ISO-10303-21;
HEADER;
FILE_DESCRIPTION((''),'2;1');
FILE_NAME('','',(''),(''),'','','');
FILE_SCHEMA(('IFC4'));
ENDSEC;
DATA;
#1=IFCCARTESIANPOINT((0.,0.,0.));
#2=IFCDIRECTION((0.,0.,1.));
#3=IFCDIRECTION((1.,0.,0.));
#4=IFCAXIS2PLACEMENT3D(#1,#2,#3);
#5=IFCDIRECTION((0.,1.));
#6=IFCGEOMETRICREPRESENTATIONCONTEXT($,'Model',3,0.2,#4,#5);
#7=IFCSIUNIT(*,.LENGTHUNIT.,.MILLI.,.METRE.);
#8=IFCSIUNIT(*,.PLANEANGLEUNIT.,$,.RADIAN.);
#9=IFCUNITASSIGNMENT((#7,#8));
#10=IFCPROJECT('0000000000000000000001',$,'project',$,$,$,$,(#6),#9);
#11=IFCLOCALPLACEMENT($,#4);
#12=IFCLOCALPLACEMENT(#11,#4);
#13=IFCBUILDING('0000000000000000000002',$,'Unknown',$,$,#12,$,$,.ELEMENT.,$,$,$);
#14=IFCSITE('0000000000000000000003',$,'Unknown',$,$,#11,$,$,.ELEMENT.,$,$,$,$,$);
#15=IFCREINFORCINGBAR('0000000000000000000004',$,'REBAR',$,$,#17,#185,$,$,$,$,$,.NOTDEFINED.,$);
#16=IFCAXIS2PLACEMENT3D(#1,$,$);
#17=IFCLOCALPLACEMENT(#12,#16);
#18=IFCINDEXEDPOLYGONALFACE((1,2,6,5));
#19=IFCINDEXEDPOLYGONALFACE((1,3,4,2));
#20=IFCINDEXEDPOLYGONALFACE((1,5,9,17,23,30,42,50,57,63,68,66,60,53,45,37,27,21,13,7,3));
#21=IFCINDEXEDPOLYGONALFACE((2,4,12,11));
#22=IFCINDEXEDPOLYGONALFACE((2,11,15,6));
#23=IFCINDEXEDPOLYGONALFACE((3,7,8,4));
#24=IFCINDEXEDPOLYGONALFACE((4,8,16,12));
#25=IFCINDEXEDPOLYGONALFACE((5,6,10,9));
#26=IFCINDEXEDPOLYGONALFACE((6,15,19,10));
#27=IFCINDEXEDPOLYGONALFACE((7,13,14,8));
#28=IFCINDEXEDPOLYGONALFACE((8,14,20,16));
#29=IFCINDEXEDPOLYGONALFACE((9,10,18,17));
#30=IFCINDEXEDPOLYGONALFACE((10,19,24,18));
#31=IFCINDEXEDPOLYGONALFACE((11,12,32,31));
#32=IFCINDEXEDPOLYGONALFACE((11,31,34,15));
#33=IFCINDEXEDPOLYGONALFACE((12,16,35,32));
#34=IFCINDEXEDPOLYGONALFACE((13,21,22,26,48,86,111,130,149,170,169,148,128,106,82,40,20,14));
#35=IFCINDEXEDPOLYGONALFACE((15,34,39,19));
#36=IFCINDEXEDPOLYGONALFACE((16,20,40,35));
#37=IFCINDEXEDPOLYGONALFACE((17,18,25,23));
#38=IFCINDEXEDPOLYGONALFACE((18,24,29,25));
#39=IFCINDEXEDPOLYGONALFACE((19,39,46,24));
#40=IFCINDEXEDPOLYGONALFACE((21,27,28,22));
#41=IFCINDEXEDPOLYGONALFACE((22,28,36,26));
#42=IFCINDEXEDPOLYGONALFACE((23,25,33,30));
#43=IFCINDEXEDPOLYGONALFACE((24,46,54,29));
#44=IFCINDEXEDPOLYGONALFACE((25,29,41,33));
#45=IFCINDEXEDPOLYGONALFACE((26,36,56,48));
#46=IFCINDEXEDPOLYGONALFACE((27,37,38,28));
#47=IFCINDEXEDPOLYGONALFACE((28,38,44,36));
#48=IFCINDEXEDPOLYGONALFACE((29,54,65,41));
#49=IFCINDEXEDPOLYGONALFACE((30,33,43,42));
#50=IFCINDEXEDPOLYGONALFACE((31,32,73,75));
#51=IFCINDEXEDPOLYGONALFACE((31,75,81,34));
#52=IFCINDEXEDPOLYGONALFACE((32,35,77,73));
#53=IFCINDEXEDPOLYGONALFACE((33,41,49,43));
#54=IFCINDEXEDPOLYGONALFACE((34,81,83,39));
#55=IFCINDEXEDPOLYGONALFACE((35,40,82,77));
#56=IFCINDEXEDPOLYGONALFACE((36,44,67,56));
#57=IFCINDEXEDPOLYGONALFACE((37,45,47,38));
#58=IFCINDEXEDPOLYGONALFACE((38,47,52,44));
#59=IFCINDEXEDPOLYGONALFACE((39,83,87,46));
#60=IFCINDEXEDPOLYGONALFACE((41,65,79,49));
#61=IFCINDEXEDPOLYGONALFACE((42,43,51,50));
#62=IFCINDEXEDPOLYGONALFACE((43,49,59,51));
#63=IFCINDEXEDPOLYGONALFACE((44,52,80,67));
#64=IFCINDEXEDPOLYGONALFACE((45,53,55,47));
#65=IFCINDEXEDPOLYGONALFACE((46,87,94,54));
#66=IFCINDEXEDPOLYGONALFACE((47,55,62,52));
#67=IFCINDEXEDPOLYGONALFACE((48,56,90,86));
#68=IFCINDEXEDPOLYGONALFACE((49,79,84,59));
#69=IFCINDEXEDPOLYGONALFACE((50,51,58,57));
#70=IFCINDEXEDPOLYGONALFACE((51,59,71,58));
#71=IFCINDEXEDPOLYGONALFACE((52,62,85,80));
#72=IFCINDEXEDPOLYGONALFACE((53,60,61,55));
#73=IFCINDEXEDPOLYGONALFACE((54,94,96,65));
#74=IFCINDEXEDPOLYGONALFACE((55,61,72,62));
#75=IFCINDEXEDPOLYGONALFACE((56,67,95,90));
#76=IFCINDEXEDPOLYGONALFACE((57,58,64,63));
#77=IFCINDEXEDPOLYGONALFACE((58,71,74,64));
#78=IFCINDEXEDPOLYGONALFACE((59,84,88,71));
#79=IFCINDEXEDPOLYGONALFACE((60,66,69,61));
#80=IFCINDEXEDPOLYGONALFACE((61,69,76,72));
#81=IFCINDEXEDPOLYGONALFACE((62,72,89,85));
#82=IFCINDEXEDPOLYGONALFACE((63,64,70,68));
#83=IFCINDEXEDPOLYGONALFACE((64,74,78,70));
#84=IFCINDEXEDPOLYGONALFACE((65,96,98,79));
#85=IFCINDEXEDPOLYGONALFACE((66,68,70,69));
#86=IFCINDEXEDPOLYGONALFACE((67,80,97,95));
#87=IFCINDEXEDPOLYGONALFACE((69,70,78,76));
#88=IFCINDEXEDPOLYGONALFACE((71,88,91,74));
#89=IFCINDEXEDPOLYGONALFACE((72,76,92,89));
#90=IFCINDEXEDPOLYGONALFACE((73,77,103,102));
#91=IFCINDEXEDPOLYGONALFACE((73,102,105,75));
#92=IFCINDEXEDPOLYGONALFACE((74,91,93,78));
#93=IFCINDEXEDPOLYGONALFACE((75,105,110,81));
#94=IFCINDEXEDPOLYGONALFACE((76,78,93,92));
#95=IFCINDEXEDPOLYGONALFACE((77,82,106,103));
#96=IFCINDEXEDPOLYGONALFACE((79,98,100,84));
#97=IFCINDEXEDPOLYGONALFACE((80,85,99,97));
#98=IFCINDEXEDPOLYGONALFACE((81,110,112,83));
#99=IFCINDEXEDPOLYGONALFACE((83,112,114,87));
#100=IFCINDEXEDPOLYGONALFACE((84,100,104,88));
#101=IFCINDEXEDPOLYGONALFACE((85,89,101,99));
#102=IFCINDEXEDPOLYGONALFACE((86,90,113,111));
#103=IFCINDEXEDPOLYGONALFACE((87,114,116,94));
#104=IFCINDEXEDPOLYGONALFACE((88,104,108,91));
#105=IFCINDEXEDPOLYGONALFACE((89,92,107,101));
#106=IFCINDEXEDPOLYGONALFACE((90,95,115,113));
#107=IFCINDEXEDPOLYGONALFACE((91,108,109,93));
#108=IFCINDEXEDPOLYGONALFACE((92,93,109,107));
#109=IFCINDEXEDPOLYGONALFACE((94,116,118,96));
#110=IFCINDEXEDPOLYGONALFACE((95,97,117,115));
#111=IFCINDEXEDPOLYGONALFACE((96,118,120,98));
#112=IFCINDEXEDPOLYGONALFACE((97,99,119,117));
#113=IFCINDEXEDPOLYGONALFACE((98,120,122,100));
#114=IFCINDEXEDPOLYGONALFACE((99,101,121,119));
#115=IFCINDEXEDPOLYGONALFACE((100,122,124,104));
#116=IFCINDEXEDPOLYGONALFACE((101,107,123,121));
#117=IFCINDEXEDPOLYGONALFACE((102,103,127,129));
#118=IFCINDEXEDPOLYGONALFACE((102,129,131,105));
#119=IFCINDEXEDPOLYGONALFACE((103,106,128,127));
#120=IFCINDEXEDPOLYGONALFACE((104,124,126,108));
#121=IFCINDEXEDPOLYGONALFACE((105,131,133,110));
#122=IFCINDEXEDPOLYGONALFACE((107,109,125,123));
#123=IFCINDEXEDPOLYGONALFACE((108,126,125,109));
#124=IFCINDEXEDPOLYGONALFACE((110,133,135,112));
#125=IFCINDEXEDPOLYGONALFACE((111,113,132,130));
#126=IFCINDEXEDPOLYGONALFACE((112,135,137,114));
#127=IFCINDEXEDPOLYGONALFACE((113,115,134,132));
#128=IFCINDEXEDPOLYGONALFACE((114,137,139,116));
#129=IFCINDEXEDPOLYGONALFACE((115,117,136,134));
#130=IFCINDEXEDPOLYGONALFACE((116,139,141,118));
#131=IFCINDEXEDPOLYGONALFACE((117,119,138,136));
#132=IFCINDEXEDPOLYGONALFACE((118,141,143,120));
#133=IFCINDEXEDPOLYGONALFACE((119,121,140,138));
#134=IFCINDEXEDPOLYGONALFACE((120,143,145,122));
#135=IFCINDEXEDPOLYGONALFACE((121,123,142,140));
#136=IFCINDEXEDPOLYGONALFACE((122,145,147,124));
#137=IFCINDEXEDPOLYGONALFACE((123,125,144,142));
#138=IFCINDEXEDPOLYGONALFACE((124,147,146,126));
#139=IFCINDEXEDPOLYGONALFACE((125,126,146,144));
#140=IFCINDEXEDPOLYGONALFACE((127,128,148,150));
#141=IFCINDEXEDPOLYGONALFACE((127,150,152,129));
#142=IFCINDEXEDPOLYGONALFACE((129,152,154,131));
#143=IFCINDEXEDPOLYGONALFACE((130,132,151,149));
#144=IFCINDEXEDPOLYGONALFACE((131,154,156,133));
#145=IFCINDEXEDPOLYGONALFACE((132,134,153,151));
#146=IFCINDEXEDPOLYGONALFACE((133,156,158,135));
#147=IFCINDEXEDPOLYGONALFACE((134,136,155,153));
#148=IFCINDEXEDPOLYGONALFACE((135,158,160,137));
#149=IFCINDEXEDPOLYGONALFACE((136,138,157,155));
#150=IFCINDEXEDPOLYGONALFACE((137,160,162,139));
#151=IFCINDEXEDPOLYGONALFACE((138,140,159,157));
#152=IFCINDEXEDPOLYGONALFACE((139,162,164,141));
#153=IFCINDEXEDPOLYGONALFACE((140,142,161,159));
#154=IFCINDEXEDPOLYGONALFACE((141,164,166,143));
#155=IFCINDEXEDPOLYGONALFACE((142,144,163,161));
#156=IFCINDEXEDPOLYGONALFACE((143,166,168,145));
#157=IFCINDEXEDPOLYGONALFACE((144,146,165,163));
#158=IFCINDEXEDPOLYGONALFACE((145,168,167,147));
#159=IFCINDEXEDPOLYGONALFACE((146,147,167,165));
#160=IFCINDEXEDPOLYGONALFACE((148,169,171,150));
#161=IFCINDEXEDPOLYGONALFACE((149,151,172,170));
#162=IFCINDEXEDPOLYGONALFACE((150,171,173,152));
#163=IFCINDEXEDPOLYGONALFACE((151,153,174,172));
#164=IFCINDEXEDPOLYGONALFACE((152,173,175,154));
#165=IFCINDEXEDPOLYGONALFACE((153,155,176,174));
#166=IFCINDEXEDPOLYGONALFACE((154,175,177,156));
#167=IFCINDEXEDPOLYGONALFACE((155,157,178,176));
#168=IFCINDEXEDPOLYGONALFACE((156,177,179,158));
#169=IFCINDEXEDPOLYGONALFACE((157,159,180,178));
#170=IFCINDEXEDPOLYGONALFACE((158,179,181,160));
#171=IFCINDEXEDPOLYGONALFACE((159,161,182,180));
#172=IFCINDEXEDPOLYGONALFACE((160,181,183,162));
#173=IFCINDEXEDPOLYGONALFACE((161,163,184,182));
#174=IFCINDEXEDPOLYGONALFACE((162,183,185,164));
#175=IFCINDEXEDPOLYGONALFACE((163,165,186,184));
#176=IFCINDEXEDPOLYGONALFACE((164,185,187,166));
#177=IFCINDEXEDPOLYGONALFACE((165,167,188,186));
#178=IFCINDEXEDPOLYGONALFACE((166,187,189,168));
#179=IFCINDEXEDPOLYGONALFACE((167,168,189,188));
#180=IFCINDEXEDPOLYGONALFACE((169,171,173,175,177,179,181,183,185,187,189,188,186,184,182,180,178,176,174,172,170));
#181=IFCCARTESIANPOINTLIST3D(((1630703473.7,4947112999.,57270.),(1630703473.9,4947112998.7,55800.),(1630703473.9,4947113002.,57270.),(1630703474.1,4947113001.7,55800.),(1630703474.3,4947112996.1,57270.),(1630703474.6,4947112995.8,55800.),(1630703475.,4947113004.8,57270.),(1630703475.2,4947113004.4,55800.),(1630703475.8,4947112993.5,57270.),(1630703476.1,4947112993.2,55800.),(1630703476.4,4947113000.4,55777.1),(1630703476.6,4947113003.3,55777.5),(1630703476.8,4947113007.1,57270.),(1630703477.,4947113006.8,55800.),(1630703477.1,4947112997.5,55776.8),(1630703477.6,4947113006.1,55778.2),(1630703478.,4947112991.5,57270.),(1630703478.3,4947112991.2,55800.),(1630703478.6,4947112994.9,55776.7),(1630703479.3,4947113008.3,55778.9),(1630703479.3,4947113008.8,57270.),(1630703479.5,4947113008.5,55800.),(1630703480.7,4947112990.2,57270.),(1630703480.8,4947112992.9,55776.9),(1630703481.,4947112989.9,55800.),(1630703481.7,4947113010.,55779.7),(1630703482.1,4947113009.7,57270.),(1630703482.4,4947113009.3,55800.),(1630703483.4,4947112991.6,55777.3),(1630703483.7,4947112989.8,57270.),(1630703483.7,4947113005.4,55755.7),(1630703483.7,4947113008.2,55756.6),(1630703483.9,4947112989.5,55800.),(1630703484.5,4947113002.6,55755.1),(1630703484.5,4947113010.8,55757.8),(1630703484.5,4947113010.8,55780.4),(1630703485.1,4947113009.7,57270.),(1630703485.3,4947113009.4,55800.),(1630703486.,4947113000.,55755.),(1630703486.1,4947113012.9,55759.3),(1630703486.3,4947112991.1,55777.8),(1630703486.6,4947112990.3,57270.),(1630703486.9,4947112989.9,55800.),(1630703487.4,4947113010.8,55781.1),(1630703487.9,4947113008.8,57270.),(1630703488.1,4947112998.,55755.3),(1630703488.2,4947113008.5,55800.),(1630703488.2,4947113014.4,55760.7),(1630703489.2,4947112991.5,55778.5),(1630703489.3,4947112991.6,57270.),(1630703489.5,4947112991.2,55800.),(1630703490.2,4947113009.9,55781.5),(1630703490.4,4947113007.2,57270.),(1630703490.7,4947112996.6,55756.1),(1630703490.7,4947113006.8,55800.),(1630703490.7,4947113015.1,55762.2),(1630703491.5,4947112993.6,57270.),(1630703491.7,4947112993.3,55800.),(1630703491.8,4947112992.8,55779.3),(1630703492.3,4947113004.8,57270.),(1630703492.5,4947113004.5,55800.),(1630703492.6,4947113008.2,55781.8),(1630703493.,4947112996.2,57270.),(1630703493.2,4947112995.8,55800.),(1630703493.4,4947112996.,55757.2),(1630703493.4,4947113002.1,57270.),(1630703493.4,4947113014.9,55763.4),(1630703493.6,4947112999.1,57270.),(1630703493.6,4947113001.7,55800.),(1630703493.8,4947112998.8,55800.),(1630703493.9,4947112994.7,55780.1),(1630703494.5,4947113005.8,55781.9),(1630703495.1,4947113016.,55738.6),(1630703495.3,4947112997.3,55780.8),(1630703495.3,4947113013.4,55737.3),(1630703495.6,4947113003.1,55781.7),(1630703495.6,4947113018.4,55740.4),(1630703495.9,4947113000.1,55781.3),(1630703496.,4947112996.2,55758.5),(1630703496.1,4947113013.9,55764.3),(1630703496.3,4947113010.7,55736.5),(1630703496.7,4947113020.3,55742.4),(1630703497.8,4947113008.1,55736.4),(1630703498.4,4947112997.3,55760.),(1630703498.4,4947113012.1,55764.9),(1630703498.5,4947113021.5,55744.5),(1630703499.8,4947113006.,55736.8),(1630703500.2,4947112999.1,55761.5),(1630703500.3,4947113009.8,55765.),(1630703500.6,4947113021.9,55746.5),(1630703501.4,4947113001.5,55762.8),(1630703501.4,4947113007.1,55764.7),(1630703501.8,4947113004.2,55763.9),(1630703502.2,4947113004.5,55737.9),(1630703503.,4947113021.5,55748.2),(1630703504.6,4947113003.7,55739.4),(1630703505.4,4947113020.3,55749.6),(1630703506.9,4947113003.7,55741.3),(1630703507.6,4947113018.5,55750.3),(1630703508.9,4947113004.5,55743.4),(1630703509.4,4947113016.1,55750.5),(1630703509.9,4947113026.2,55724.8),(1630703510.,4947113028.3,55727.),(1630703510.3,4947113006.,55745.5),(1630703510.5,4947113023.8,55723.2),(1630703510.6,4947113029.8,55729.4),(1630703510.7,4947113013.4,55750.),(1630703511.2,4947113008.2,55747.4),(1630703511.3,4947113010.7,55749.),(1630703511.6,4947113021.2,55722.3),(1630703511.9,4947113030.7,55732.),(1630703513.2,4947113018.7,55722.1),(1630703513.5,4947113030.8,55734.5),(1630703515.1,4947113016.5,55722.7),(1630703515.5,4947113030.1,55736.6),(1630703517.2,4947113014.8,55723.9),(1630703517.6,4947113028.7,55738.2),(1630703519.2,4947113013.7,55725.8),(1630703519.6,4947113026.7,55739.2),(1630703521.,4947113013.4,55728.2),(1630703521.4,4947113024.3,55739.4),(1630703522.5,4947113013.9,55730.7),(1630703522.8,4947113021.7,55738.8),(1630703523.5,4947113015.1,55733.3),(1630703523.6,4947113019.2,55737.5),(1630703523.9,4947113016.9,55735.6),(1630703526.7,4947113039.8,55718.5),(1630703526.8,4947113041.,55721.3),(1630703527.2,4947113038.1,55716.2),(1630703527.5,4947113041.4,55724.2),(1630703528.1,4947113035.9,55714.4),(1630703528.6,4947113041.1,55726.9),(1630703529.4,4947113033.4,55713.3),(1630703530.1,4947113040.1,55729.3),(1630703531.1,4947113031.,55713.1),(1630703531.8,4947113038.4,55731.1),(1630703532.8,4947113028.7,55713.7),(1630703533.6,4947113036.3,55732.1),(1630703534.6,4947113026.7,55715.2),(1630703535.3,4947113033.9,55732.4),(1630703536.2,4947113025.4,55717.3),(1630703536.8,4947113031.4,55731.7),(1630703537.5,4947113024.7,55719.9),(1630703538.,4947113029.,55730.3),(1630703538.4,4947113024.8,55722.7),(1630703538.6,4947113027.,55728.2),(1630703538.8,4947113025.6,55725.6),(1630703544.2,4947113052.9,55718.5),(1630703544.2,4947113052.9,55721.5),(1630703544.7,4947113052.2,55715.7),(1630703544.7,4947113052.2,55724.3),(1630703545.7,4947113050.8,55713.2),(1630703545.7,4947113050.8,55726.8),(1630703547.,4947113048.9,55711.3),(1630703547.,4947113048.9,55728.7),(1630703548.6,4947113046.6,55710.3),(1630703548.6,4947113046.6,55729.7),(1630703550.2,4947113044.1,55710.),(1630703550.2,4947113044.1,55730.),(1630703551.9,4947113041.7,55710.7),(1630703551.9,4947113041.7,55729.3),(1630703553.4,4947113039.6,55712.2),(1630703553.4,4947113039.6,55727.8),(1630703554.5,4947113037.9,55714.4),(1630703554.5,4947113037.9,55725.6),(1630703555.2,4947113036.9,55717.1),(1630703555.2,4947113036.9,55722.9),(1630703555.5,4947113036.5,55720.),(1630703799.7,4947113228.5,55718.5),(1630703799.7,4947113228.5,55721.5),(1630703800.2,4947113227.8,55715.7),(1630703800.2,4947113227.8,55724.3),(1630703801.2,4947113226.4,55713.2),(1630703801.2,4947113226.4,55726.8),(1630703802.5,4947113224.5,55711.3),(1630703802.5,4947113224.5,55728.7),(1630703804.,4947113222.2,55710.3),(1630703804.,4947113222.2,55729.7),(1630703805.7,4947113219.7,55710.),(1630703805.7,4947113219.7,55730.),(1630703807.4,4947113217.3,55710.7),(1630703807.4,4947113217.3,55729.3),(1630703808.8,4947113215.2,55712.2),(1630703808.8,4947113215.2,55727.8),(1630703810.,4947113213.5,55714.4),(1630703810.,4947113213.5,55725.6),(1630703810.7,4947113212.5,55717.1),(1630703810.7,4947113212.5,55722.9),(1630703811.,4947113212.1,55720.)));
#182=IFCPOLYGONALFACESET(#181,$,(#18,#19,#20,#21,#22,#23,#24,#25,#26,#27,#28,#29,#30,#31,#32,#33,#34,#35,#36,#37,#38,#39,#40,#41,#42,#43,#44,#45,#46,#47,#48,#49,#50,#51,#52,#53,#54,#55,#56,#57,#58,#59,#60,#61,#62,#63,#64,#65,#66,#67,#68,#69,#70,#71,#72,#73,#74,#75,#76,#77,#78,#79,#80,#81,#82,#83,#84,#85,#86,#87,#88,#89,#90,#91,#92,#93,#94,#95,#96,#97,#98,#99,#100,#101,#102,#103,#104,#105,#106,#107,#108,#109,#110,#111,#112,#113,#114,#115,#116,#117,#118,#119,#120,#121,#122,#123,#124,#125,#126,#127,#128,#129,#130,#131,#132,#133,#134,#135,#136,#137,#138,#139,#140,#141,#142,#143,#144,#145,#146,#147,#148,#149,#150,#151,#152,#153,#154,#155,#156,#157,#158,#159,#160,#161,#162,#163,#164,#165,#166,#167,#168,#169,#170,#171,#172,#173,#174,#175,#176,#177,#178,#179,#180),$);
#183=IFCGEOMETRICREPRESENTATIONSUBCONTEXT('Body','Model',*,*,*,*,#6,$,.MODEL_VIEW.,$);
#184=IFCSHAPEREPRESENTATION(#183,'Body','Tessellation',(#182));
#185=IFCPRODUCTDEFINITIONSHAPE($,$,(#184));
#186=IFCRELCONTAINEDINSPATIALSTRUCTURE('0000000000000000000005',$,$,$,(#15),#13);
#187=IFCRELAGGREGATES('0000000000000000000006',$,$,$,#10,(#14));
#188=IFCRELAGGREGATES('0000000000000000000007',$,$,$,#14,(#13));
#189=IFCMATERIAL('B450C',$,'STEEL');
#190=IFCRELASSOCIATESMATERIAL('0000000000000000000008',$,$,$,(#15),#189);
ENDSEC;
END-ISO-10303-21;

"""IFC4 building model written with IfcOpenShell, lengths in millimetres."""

from ifc_helpers import new_model, entity, si_unit, direction, frame, origin_with_axes, place, context, subcontext, project, spatial, material, element, save


model = new_model("IFC4")

# Units and contexts
model_context = context("Model", 3, precision=0.2, world=origin_with_axes(), true_north=direction((0.0, 1.0)))
body_context = subcontext(model_context, "Body", "Model", "MODEL_VIEW")
ifc_project = project(units=[si_unit("LENGTHUNIT", "METRE", prefix="MILLI"), si_unit("PLANEANGLEUNIT", "RADIAN")], contexts=[model_context])

# Site, building
site_placement = place(None, origin_with_axes())
site = spatial("IfcSite", under=ifc_project, at=site_placement, Name="Unknown", CompositionType="ELEMENT")
building_placement = place(site_placement, origin_with_axes())
building = spatial("IfcBuilding", under=site, at=building_placement, Name="Unknown", CompositionType="ELEMENT")

# Reinforcing bar
ifc_material = material(Name="B450C", Category="STEEL")
reinforcing_bar_1_placement = place(building_placement, frame((1630703414.4, 4947113012.3, 55670.0), z_axis=(0.566651, -0.823958, 0.0), x_axis=(0.0, 0.0, 1.0)))
element("IfcReinforcingBar", 1, at=reinforcing_bar_1_placement, inside=building, material=ifc_material, Name="REBAR", PredefinedType="NOTDEFINED", context=body_context, shape_type="AdvancedSweptSolid", body=[
    entity("IfcSweptDiskSolid", entity("IfcIndexedPolyCurve", entity("IfcCartesianPointList3D", [[50.0, -440.0, 50.1], [50.0, -130.0, 50.0], [73.4, -73.4, 50.0], [130.0, -50.0, 50.0], [1600.0, -50.0, 49.6]]), [entity("IfcLineIndex", [1, 2]), entity("IfcArcIndex", [2, 3, 4]), entity("IfcLineIndex", [4, 5])]), 10.0),
])

save(model, "model.ifc")
